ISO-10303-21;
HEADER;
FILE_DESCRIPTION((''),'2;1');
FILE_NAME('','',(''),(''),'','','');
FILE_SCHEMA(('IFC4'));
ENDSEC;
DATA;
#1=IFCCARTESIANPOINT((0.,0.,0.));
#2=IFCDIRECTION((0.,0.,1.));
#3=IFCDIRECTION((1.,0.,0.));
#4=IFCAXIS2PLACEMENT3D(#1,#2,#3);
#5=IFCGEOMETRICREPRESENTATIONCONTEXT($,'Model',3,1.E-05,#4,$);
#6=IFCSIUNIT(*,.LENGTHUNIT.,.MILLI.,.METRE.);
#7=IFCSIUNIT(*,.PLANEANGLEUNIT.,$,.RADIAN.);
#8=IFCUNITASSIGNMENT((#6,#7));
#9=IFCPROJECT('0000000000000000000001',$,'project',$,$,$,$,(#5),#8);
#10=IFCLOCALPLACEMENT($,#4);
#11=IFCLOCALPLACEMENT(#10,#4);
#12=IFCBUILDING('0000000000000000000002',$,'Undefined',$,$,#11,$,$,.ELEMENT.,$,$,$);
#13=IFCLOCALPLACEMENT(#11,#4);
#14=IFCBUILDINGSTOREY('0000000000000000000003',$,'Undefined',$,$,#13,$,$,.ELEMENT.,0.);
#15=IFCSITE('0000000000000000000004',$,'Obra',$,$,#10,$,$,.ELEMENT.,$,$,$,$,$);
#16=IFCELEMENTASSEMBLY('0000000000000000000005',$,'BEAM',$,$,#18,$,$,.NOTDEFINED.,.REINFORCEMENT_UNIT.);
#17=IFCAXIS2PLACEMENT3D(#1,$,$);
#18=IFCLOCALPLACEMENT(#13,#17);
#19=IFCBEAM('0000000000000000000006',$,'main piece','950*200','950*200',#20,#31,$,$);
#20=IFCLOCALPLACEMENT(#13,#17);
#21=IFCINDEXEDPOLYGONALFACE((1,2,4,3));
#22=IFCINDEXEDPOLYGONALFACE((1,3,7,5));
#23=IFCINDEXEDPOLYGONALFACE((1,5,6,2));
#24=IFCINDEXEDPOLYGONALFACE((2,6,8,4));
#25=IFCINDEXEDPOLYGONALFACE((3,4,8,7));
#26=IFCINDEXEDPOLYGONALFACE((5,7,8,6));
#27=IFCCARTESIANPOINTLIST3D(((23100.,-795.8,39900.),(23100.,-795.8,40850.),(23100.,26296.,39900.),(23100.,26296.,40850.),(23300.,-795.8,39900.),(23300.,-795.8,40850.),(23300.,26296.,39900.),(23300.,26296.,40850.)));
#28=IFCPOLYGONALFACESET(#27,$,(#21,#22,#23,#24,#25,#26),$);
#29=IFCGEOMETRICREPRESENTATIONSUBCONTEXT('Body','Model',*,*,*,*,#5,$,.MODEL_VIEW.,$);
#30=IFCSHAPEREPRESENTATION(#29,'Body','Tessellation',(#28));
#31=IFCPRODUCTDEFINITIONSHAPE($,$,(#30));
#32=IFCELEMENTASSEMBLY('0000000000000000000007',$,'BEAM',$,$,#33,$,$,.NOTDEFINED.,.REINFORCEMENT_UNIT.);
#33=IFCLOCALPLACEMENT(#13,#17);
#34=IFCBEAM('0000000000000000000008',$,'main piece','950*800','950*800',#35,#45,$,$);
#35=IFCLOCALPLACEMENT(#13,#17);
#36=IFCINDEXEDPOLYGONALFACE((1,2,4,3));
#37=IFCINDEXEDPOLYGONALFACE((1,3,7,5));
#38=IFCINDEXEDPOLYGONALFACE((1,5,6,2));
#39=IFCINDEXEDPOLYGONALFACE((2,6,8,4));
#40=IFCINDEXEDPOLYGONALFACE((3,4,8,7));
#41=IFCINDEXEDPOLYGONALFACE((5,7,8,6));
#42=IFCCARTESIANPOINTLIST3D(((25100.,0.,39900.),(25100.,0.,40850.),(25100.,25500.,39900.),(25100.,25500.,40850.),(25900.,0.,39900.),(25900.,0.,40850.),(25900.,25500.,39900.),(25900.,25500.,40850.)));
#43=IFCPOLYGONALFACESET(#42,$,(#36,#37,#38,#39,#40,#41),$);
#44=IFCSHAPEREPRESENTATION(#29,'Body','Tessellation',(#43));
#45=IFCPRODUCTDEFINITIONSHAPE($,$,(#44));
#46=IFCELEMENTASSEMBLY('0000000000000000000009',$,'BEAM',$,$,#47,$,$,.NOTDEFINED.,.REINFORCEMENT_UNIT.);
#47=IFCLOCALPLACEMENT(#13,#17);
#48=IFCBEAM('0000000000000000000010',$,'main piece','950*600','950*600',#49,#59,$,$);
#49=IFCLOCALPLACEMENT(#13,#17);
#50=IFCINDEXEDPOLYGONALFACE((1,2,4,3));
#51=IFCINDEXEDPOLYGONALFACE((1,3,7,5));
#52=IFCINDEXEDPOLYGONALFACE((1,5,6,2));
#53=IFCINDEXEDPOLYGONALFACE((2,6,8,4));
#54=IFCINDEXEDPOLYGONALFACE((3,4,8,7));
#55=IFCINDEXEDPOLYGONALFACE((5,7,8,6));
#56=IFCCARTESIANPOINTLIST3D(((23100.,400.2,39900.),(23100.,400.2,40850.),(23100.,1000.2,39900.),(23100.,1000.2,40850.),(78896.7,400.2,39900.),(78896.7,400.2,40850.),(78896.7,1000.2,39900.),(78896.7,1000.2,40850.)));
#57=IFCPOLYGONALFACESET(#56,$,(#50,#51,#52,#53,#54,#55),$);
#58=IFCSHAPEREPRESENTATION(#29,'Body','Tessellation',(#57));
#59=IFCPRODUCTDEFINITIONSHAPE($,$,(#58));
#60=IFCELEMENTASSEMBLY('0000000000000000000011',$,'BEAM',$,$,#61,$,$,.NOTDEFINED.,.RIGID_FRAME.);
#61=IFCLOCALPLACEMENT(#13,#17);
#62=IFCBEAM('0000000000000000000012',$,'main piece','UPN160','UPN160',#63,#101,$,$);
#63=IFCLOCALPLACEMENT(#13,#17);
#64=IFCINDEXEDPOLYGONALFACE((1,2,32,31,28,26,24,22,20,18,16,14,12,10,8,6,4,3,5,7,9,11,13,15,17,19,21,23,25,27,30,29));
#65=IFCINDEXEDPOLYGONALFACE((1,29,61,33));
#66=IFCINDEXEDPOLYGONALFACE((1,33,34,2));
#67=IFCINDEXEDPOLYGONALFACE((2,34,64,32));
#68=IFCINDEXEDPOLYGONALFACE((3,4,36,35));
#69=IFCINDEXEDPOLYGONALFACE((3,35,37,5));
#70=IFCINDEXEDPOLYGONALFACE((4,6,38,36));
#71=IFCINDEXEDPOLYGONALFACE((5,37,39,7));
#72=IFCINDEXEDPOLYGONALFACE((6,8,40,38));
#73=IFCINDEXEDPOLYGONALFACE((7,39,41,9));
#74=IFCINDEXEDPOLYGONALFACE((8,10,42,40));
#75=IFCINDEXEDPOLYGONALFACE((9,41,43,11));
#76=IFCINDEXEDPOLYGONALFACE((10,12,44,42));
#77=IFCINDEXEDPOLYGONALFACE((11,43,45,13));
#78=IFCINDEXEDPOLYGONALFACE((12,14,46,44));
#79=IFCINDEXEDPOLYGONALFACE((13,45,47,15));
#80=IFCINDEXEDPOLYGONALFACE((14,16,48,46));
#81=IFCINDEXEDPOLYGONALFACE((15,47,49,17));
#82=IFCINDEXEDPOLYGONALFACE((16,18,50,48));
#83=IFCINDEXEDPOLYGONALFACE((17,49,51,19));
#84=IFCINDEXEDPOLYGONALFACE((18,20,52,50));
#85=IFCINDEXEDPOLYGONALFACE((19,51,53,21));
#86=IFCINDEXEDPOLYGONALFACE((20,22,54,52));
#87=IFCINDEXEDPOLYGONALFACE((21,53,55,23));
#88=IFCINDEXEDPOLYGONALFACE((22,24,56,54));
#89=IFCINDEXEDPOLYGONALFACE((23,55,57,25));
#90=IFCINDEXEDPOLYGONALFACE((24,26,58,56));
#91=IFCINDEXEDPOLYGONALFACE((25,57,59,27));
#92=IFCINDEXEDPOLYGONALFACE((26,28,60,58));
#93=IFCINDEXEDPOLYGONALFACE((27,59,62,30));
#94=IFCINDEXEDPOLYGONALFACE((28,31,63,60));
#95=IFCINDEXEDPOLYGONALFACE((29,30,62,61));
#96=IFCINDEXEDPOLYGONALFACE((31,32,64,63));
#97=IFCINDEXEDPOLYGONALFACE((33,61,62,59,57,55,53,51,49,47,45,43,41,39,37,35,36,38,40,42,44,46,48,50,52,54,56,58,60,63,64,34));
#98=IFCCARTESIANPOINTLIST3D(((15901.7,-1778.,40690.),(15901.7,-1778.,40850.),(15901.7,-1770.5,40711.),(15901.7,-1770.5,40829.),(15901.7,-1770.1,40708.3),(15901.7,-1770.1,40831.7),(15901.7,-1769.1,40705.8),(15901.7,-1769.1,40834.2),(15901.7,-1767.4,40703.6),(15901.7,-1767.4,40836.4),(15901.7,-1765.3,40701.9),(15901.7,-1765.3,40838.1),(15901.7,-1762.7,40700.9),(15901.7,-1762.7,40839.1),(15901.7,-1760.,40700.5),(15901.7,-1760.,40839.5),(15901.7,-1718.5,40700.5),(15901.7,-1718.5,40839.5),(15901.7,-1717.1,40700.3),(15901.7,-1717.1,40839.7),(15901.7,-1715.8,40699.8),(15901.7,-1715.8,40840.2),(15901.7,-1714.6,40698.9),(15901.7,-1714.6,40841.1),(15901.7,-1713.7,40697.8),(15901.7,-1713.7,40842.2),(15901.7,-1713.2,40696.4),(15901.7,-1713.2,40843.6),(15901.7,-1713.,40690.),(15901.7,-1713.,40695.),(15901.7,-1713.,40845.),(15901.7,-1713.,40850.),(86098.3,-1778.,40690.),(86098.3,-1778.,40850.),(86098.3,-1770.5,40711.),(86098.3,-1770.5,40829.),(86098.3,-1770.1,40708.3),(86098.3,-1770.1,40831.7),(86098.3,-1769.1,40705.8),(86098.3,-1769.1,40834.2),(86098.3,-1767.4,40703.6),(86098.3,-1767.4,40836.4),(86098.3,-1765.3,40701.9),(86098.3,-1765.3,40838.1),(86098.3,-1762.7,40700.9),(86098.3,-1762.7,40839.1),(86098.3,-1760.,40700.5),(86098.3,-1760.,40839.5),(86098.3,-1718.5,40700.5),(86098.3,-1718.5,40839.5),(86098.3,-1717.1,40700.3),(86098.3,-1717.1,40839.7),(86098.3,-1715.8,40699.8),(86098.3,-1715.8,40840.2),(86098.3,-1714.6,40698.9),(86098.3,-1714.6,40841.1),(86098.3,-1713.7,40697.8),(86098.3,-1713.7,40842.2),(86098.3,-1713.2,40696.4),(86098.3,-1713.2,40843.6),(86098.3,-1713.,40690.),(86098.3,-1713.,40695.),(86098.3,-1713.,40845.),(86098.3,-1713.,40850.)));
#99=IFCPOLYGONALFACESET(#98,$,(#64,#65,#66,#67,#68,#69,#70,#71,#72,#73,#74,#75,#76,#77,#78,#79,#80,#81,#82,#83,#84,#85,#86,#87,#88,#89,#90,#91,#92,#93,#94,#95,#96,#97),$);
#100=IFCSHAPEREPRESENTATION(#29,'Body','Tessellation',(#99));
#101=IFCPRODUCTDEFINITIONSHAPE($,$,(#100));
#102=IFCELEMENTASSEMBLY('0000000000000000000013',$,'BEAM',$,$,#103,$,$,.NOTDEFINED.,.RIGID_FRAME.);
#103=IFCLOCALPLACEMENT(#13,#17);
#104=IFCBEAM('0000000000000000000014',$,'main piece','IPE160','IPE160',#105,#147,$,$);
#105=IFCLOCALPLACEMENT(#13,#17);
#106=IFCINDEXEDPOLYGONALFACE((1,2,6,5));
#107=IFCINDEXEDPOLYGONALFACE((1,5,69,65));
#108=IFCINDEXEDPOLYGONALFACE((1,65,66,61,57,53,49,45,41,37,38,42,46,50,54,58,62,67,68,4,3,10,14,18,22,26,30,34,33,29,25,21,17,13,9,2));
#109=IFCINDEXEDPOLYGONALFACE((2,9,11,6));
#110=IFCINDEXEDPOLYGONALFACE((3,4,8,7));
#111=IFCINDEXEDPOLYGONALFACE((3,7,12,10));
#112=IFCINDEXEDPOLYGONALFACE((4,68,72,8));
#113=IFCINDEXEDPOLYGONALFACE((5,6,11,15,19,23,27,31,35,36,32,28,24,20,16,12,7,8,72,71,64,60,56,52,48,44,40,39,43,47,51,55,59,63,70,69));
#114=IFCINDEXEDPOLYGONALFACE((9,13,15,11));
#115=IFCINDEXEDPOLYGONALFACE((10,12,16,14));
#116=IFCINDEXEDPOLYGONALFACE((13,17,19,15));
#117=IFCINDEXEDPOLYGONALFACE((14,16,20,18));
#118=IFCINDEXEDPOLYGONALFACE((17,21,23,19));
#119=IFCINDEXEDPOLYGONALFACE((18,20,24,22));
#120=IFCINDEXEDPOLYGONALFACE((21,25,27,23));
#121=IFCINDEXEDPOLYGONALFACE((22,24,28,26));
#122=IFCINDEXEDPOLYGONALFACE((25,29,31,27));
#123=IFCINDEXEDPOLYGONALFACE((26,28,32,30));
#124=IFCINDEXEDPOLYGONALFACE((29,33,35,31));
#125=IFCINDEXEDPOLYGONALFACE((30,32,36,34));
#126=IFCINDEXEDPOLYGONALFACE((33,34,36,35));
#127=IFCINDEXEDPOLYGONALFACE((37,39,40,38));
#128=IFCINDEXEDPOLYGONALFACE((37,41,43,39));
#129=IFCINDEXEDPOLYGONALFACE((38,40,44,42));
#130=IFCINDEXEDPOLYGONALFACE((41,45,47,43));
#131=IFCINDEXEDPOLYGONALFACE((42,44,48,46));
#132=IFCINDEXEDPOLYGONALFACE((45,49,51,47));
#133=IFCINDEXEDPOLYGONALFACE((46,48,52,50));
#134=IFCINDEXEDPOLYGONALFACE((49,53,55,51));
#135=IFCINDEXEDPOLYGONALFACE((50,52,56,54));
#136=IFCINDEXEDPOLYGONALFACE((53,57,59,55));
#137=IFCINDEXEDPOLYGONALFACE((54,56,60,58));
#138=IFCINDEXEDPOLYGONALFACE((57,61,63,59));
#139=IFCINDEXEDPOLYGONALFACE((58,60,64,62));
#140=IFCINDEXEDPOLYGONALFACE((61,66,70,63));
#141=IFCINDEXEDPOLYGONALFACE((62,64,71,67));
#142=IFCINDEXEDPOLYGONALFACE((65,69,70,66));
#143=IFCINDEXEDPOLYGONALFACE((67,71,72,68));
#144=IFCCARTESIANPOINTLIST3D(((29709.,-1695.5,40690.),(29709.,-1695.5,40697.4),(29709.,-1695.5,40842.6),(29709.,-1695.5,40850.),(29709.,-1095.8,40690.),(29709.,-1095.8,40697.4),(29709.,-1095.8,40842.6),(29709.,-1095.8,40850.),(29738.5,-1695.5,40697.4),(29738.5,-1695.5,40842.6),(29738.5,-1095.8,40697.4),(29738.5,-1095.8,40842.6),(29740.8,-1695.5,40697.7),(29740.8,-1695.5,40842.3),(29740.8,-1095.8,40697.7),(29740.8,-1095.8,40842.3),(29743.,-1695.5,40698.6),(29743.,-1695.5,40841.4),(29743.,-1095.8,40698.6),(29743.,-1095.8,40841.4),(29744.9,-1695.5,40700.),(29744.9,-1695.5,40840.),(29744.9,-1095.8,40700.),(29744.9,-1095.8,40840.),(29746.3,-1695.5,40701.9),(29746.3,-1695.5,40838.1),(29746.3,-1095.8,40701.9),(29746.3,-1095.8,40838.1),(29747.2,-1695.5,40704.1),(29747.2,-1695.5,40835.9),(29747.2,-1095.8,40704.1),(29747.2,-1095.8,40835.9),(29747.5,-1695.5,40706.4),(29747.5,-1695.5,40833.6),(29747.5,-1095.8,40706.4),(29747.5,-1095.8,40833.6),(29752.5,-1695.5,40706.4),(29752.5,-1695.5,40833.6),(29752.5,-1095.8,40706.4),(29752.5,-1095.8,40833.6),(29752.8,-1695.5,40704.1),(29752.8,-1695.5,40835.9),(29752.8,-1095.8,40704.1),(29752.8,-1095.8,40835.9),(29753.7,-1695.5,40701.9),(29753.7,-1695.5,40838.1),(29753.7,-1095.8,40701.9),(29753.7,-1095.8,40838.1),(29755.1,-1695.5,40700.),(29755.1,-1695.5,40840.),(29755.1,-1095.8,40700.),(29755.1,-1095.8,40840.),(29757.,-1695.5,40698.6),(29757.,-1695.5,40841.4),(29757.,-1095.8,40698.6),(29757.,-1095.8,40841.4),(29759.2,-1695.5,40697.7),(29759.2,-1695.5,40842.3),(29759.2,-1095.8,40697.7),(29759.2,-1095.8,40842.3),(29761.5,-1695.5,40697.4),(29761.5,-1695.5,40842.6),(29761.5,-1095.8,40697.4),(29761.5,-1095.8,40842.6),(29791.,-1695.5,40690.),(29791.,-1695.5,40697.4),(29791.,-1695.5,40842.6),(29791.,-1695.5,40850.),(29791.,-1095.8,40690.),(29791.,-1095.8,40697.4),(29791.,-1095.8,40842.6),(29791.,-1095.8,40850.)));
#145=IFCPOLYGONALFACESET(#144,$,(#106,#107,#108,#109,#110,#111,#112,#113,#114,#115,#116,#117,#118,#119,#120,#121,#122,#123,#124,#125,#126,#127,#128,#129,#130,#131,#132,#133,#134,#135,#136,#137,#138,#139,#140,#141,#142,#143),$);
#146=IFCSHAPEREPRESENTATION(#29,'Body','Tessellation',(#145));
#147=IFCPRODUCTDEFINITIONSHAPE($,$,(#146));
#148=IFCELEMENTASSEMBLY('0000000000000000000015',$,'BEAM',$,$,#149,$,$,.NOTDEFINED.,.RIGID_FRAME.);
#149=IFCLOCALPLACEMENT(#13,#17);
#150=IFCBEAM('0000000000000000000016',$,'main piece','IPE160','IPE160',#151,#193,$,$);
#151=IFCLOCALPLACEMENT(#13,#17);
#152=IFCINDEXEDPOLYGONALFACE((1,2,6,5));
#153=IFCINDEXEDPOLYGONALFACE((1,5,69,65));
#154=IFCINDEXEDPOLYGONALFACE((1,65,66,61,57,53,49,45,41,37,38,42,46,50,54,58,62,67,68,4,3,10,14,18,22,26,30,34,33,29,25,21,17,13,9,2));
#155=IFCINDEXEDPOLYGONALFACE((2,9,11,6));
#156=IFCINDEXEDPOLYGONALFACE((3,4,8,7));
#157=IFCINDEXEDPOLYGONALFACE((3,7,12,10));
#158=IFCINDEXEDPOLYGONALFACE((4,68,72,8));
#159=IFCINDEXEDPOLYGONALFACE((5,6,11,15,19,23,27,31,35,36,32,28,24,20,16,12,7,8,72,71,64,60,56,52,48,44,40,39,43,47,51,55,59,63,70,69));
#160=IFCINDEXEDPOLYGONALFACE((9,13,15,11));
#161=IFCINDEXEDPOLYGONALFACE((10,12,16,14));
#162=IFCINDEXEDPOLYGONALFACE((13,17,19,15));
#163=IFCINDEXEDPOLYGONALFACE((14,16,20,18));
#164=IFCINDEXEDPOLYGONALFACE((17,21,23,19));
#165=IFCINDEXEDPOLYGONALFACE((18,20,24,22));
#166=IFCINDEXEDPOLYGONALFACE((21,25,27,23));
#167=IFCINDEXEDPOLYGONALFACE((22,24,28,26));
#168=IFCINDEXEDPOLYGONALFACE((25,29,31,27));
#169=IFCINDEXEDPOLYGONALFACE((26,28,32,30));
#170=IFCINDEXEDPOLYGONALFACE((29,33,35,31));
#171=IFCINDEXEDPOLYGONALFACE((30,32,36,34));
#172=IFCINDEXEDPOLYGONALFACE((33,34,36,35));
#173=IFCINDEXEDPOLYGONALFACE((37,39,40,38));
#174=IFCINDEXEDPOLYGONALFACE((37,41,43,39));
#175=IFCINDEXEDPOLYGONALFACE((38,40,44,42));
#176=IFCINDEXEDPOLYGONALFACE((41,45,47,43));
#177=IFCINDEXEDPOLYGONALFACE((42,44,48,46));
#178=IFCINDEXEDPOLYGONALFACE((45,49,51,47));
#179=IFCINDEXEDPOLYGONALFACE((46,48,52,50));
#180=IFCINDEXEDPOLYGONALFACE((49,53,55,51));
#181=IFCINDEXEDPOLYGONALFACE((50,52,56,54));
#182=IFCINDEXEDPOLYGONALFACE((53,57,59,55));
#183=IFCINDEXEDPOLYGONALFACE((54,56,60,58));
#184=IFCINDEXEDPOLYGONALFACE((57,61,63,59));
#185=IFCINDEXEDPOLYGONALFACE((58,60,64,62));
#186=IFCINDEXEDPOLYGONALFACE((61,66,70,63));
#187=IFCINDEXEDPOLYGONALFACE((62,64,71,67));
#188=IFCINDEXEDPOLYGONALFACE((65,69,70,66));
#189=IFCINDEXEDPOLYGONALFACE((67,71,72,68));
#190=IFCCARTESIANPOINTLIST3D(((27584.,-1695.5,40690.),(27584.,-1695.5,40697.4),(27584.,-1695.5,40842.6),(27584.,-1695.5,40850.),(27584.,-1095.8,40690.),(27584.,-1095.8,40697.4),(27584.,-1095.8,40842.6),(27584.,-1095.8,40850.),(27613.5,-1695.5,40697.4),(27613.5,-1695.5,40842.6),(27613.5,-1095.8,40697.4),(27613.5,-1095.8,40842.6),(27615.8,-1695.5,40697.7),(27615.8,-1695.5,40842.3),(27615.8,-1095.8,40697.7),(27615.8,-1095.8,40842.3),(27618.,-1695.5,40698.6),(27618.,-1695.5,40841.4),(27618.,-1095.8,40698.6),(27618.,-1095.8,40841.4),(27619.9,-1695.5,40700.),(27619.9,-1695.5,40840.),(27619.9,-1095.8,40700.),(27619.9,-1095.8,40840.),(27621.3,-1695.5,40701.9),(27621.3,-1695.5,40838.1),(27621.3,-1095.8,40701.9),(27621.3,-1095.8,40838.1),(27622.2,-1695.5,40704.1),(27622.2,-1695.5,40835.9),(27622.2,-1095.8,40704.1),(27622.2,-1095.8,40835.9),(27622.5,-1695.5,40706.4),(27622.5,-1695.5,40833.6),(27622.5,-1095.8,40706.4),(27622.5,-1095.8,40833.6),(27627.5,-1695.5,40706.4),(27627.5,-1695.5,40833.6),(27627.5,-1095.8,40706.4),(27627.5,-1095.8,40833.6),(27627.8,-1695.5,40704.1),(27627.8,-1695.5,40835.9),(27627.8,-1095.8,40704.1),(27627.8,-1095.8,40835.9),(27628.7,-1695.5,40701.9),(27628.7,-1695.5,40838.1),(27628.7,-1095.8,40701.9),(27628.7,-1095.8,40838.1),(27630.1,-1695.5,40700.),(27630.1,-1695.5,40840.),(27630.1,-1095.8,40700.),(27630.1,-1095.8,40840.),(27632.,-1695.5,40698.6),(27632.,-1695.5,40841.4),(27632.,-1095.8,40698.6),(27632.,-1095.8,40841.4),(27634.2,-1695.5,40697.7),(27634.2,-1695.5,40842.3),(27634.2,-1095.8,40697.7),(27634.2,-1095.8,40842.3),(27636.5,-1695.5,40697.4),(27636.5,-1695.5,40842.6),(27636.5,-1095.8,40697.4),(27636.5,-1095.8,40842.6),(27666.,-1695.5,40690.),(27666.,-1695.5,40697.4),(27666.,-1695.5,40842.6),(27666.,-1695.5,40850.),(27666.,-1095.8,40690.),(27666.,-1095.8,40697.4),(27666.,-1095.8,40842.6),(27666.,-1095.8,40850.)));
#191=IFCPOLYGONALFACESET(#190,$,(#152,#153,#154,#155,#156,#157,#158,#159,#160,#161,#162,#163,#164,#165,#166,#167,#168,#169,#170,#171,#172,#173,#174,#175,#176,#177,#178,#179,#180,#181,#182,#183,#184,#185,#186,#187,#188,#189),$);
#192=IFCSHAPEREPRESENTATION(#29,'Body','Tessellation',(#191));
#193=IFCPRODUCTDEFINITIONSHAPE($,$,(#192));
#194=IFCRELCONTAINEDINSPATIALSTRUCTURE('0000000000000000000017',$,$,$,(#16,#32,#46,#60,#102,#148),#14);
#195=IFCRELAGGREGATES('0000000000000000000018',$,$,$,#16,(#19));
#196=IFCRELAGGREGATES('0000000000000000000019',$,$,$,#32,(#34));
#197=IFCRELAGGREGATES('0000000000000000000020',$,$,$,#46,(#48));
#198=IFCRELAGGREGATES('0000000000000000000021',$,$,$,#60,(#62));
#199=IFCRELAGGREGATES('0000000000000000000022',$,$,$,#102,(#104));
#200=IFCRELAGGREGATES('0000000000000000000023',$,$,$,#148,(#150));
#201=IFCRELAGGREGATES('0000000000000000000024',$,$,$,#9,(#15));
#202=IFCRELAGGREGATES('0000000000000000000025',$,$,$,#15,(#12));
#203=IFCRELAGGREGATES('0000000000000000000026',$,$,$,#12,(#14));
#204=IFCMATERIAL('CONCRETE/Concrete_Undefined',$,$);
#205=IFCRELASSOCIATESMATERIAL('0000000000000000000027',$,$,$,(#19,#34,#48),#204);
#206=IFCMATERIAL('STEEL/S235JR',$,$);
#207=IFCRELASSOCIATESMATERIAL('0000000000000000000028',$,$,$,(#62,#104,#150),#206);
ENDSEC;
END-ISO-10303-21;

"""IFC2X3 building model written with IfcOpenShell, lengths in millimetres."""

from ifc_helpers import new_model, si_unit, frame, origin_with_axes, origin_2d_with_axis, place, context, subcontext, project, spatial, rectangle, i_section, u_section, extrude, material, element, aggregate, save


model = new_model("IFC2X3")

# Units and contexts
model_context = context("Model", 3, precision=1e-05, world=origin_with_axes())
body_context = subcontext(model_context, "Body", "Model", "MODEL_VIEW")
ifc_project = project(units=[si_unit("LENGTHUNIT", "METRE", prefix="MILLI"), si_unit("PLANEANGLEUNIT", "RADIAN")], contexts=[model_context])

# Site, building, storey
site_placement = place(None, origin_with_axes())
site = spatial("IfcSite", under=ifc_project, at=site_placement, Name="Obra", CompositionType="ELEMENT")
building_placement = place(site_placement, origin_with_axes())
building = spatial("IfcBuilding", under=site, at=building_placement, Name="Undefined", CompositionType="ELEMENT")
storey_placement = place(building_placement, origin_with_axes())
storey = spatial("IfcBuildingStorey", under=building, at=storey_placement, Name="Undefined", CompositionType="ELEMENT", Elevation=0.0)

# Shared definitions
ifc_material_1 = material(Name="STEEL/S235JR")

# Element assemblies, beams
ifc_material_2 = material(Name="CONCRETE/Concrete_Undefined")
assembly_1_placement = place(storey_placement, origin_with_axes())
assembly_1 = element("IfcElementAssembly", 1, at=assembly_1_placement, inside=storey, Name="BEAM", AssemblyPlace="NOTDEFINED", PredefinedType="REINFORCEMENT_UNIT")
beam_1_placement = place(assembly_1_placement, frame((23200.0, -795.8, 40375.0), z_axis=(0.0, 0.0, 1.0), x_axis=(0.0, 1.0, 0.0)))
beam_1 = element("IfcBeam", 2, at=beam_1_placement, material=ifc_material_2, Name="main piece", Description="950*200", ObjectType="950*200", context=body_context, shape_type="SweptSolid", body=[
    extrude(rectangle(XDim=200.0, YDim=950.0, at=origin_2d_with_axis()), frame((27091.8, 0.0, 0.0), z_axis=(-1.0, 0.0, 0.0), x_axis=(0.0, -1.0, 0.0)), (0.0, 0.0, 1.0), 27091.8),
])
aggregate(assembly_1, [beam_1])
assembly_2_placement = place(storey_placement, origin_with_axes())
assembly_2 = element("IfcElementAssembly", 3, at=assembly_2_placement, inside=storey, Name="BEAM", AssemblyPlace="NOTDEFINED", PredefinedType="REINFORCEMENT_UNIT")
beam_2_placement = place(assembly_2_placement, frame((25500.0, 0.0, 40375.0), z_axis=(0.0, 0.0, 1.0), x_axis=(0.0, 1.0, 0.0)))
beam_2 = element("IfcBeam", 4, at=beam_2_placement, material=ifc_material_2, Name="main piece", Description="950*800", ObjectType="950*800", context=body_context, shape_type="SweptSolid", body=[
    extrude(rectangle(XDim=800.0, YDim=950.0, at=origin_2d_with_axis()), frame((25500.0, 0.0, 0.0), z_axis=(-1.0, 0.0, 0.0), x_axis=(0.0, -1.0, 0.0)), (0.0, 0.0, 1.0), 25500.0),
])
aggregate(assembly_2, [beam_2])
assembly_3_placement = place(storey_placement, origin_with_axes())
assembly_3 = element("IfcElementAssembly", 5, at=assembly_3_placement, inside=storey, Name="BEAM", AssemblyPlace="NOTDEFINED", PredefinedType="REINFORCEMENT_UNIT")
beam_3_placement = place(assembly_3_placement, frame((23100.0, 700.2, 40375.0), z_axis=(0.0, 0.0, 1.0), x_axis=(1.0, 0.0, 0.0)))
beam_3 = element("IfcBeam", 6, at=beam_3_placement, material=ifc_material_2, Name="main piece", Description="950*600", ObjectType="950*600", context=body_context, shape_type="SweptSolid", body=[
    extrude(rectangle(XDim=600.0, YDim=950.0, at=origin_2d_with_axis()), frame((55796.7, 0.0, 0.0), z_axis=(-1.0, 0.0, 0.0), x_axis=(0.0, -1.0, 0.0)), (0.0, 0.0, 1.0), 55796.7),
])
aggregate(assembly_3, [beam_3])
assembly_4_placement = place(storey_placement, origin_with_axes())
assembly_4 = element("IfcElementAssembly", 7, at=assembly_4_placement, inside=storey, Name="BEAM", AssemblyPlace="NOTDEFINED", PredefinedType="RIGID_FRAME")
beam_4_placement = place(assembly_4_placement, frame((15901.7, -1745.5, 40770.0), z_axis=(0.0, 0.0, -1.0), x_axis=(1.0, 0.0, 0.0)))
beam_4 = element("IfcBeam", 8, at=beam_4_placement, material=ifc_material_1, Name="main piece", Description="UPN160", ObjectType="UPN160", context=body_context, shape_type="SweptSolid", body=[
    extrude(u_section(Depth=160.0, FlangeWidth=65.0, WebThickness=7.5, FlangeThickness=10.5, FilletRadius=10.5, EdgeRadius=5.5, at=origin_2d_with_axis()), frame((70196.6, 0.0, 0.0), z_axis=(-1.0, 0.0, 0.0), x_axis=(0.0, -1.0, 0.0)), (0.0, 0.0, 1.0), 70196.6),
])
aggregate(assembly_4, [beam_4])
assembly_5_placement = place(storey_placement, origin_with_axes())
assembly_5 = element("IfcElementAssembly", 9, at=assembly_5_placement, inside=storey, Name="BEAM", AssemblyPlace="NOTDEFINED", PredefinedType="RIGID_FRAME")
beam_5_placement = place(assembly_5_placement, frame((29750.0, -1095.8, 40770.0), z_axis=(0.0, 0.0, 1.0), x_axis=(0.0, -1.0, 0.0)))
beam_5 = element("IfcBeam", 10, at=beam_5_placement, material=ifc_material_1, Name="main piece", Description="IPE160", ObjectType="IPE160", context=body_context, shape_type="SweptSolid", body=[
    extrude(i_section(OverallWidth=82.0, OverallDepth=160.0, WebThickness=5.0, FlangeThickness=7.4, FilletRadius=9.0, at=origin_2d_with_axis()), frame((599.7, 0.0, 0.0), z_axis=(-1.0, 0.0, 0.0), x_axis=(0.0, -1.0, 0.0)), (0.0, 0.0, 1.0), 599.7),
])
aggregate(assembly_5, [beam_5])
assembly_6_placement = place(storey_placement, origin_with_axes())
assembly_6 = element("IfcElementAssembly", 11, at=assembly_6_placement, inside=storey, Name="BEAM", AssemblyPlace="NOTDEFINED", PredefinedType="RIGID_FRAME")
beam_6_placement = place(assembly_6_placement, frame((27625.0, -1695.5, 40770.0), z_axis=(0.0, 0.0, 1.0), x_axis=(0.0, 1.0, 0.0)))
beam_6 = element("IfcBeam", 12, at=beam_6_placement, material=ifc_material_1, Name="main piece", Description="IPE160", ObjectType="IPE160", context=body_context, shape_type="SweptSolid", body=[
    extrude(i_section(OverallWidth=82.0, OverallDepth=160.0, WebThickness=5.0, FlangeThickness=7.4, FilletRadius=9.0, at=origin_2d_with_axis()), frame((599.7, 0.0, 0.0), z_axis=(-1.0, 0.0, 0.0), x_axis=(0.0, -1.0, 0.0)), (0.0, 0.0, 1.0), 599.7),
])
aggregate(assembly_6, [beam_6])

save(model, "model.ifc")
